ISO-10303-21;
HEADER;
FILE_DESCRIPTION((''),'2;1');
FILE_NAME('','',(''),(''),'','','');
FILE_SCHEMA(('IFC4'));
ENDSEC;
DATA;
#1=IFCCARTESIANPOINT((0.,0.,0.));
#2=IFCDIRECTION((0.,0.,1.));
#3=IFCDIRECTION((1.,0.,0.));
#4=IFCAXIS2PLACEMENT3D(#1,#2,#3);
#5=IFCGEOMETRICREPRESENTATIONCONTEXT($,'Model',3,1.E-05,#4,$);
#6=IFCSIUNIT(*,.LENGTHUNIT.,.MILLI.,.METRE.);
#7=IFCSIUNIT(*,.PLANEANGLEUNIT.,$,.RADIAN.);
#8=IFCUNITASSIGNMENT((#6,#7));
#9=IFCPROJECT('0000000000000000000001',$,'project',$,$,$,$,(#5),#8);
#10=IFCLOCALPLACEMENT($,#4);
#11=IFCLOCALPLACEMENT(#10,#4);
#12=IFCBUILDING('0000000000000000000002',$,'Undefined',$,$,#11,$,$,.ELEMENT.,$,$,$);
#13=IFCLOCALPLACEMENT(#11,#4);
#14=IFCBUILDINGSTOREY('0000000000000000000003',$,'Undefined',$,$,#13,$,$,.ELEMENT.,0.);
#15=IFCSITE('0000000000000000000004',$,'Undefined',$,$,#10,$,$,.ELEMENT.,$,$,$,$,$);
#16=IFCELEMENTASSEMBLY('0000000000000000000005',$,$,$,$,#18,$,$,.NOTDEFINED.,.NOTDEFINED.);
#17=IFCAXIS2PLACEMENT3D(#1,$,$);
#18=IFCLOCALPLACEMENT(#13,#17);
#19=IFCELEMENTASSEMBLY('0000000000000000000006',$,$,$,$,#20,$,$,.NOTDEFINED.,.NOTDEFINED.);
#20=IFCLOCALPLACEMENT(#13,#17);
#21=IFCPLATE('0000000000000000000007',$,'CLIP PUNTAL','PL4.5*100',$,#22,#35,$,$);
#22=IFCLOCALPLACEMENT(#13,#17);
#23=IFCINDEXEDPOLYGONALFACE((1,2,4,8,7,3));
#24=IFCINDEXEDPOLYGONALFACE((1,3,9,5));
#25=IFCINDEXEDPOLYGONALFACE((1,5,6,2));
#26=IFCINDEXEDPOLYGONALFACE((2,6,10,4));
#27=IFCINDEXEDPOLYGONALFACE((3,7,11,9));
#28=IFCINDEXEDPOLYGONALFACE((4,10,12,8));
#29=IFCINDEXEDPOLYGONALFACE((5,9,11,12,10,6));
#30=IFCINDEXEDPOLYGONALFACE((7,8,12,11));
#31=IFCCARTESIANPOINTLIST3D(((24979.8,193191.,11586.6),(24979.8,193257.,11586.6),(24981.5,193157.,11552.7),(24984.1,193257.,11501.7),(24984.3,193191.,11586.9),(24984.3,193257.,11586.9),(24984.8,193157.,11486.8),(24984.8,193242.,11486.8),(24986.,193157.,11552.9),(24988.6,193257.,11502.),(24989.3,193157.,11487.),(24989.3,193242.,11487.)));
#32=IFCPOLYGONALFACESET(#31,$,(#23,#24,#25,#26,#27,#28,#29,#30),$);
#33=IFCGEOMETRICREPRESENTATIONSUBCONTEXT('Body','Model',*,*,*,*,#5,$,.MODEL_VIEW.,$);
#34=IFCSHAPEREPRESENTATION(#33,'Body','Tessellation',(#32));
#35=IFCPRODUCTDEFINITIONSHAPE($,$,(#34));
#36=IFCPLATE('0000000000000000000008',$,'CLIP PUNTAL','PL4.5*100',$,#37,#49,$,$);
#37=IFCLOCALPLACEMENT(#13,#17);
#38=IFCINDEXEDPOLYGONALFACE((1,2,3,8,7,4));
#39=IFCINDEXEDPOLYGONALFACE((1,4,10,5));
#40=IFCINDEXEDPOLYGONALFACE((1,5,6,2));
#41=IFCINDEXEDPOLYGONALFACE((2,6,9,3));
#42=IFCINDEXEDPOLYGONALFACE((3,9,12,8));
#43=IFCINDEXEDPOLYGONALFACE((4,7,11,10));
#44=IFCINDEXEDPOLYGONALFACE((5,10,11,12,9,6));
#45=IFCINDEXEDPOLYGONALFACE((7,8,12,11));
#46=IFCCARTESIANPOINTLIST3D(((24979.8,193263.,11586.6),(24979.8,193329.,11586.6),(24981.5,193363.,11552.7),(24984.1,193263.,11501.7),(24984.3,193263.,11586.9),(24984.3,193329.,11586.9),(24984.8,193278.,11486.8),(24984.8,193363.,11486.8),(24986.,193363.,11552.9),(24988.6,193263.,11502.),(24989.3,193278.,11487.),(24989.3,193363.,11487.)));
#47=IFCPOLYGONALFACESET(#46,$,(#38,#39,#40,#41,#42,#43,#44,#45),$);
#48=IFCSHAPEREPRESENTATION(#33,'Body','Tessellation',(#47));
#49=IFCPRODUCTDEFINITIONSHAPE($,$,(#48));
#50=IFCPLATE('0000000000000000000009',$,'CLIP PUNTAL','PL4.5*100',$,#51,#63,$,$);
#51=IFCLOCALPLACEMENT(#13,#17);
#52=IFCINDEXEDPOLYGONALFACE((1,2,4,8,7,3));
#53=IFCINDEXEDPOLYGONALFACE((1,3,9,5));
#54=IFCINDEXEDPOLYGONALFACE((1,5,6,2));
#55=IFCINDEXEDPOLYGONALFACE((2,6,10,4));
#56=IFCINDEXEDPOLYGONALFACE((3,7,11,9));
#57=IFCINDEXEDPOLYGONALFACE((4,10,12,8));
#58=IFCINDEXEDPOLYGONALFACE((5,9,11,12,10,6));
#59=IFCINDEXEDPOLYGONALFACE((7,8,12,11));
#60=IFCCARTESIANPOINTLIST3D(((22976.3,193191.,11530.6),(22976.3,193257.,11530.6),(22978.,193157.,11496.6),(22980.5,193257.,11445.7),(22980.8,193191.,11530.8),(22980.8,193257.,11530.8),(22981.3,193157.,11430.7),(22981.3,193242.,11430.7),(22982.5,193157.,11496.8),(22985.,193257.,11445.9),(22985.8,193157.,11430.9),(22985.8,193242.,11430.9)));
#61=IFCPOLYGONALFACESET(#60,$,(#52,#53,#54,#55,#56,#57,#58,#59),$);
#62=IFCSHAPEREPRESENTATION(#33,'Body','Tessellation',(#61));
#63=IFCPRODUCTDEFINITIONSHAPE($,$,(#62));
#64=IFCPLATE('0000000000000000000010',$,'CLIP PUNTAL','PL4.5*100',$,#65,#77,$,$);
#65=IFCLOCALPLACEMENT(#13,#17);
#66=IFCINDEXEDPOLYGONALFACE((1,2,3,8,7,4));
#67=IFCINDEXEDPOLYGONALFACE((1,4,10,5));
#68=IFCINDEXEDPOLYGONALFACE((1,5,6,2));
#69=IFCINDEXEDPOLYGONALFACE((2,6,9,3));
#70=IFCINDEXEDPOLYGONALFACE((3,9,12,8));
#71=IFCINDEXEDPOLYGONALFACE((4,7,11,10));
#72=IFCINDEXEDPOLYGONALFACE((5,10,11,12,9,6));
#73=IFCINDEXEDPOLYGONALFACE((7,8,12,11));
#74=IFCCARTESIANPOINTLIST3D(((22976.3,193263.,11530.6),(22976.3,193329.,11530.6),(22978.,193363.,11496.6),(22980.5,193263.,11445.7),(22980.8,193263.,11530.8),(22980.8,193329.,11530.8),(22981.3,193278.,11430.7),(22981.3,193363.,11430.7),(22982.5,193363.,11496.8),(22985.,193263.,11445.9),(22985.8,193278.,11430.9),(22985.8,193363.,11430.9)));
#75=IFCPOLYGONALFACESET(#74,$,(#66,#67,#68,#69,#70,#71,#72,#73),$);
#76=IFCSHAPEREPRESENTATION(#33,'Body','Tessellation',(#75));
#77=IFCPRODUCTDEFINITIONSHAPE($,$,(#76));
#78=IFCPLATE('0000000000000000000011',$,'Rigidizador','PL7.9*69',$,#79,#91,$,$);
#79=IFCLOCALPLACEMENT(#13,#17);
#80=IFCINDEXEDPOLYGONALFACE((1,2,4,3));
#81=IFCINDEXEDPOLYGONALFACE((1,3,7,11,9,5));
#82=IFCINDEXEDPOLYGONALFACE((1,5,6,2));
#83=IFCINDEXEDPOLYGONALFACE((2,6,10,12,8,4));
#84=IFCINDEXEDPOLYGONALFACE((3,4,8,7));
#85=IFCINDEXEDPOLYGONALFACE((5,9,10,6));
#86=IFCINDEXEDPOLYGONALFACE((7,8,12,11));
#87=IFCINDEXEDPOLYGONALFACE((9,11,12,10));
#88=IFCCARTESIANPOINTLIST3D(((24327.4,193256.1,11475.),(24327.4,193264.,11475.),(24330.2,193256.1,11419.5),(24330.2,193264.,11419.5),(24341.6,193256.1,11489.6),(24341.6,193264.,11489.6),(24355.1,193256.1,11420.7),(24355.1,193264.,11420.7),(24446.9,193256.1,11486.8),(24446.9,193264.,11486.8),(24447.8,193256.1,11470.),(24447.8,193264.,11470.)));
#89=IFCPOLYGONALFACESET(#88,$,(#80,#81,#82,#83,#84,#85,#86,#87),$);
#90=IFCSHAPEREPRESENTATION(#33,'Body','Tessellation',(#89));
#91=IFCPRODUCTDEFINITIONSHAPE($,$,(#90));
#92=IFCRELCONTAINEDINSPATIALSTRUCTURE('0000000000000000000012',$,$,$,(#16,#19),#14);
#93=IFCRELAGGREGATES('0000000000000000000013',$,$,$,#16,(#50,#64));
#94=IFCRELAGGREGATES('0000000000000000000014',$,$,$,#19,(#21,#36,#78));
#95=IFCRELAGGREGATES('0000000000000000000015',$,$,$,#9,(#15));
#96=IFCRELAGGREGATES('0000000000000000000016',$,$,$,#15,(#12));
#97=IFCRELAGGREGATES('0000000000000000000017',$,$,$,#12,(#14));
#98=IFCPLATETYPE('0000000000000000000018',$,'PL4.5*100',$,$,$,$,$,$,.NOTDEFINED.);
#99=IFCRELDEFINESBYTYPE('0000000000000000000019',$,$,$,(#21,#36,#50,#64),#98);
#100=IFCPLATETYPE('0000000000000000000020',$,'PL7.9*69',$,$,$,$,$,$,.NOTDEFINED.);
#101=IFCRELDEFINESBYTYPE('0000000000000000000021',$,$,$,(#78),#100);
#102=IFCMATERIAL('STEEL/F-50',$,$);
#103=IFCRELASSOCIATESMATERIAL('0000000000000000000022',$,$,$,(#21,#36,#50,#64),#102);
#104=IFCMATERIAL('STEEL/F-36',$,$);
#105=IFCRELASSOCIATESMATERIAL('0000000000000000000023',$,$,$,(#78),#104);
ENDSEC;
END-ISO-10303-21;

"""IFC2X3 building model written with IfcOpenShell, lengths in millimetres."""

from ifc_helpers import new_model, si_unit, frame, origin_with_axes, place, context, subcontext, project, spatial, polyline, outline, extrude, material, type_object, element, aggregate, save


model = new_model("IFC2X3")

# Units and contexts
model_context = context("Model", 3, precision=1e-05, world=origin_with_axes())
body_context = subcontext(model_context, "Body", "Model", "MODEL_VIEW")
ifc_project = project(units=[si_unit("LENGTHUNIT", "METRE", prefix="MILLI"), si_unit("PLANEANGLEUNIT", "RADIAN")], contexts=[model_context])

# Site, building, storey
site_placement = place(None, origin_with_axes())
site = spatial("IfcSite", under=ifc_project, at=site_placement, Name="Undefined", CompositionType="ELEMENT")
building_placement = place(site_placement, origin_with_axes())
building = spatial("IfcBuilding", under=site, at=building_placement, Name="Undefined", CompositionType="ELEMENT")
storey_placement = place(building_placement, origin_with_axes())
storey = spatial("IfcBuildingStorey", under=building, at=storey_placement, Name="Undefined", CompositionType="ELEMENT", Elevation=0.0)

# Element assemblies
assembly_1_placement = place(storey_placement, origin_with_axes())
assembly_1 = element("IfcElementAssembly", 1, at=assembly_1_placement, inside=storey, AssemblyPlace="NOTDEFINED", PredefinedType="NOTDEFINED")
ifc_material_1 = material(Name="STEEL/F-50")
assembly_2_placement = place(storey_placement, origin_with_axes())
assembly_2 = element("IfcElementAssembly", 2, at=assembly_2_placement, inside=storey, AssemblyPlace="NOTDEFINED", PredefinedType="NOTDEFINED")
ifc_material_2 = material(Name="STEEL/F-36")

# Plates
plate_type_1 = type_object("IfcPlateType", Name="PL4.5*100", PredefinedType="NOTDEFINED")
plate_1_placement = place(assembly_2_placement, frame((24982.1, 193257.0, 11586.8), z_axis=(0.998754, 0.0, 0.049896), x_axis=(0.0, -1.0, 0.0)))
plate_1 = element("IfcPlate", 3, at=plate_1_placement, type_object=plate_type_1, material=ifc_material_1, Name="CLIP PUNTAL", Description="PL4.5*100", context=body_context, shape_type="SweptSolid", body=[
    extrude(outline(polyline([(0.0, 0.0), (66.0, 0.0), (100.0, 34.0), (100.0, 100.0), (15.0, 100.0), (0.0, 85.0), (0.0, 0.0)])), frame((0.0, 0.0, -2.2), z_axis=(0.0, 0.0, 1.0), x_axis=(1.0, 0.0, 0.0)), (0.0, 0.0, 1.0), 4.5),
])
plate_2_placement = place(assembly_2_placement, frame((24982.1, 193263.0, 11586.8), z_axis=(-0.998754, 0.0, -0.049896), x_axis=(0.0, 1.0, 0.0)))
plate_2 = element("IfcPlate", 4, at=plate_2_placement, type_object=plate_type_1, material=ifc_material_1, Name="CLIP PUNTAL", Description="PL4.5*100", context=body_context, shape_type="SweptSolid", body=[
    extrude(outline(polyline([(0.0, 0.0), (66.0, 0.0), (100.0, 34.0), (100.0, 100.0), (15.0, 100.0), (0.0, 85.0), (0.0, 0.0)])), frame((0.0, 0.0, -2.2), z_axis=(0.0, 0.0, 1.0), x_axis=(1.0, 0.0, 0.0)), (0.0, 0.0, 1.0), 4.5),
])
plate_3_placement = place(assembly_1_placement, frame((22978.5, 193257.0, 11530.7), z_axis=(0.998754, 0.0, 0.049896), x_axis=(0.0, -1.0, 0.0)))
plate_3 = element("IfcPlate", 5, at=plate_3_placement, type_object=plate_type_1, material=ifc_material_1, Name="CLIP PUNTAL", Description="PL4.5*100", context=body_context, shape_type="SweptSolid", body=[
    extrude(outline(polyline([(0.0, 0.0), (66.0, 0.0), (100.0, 34.0), (100.0, 100.0), (15.0, 100.0), (0.0, 85.0), (0.0, 0.0)])), frame((0.0, 0.0, -2.2), z_axis=(0.0, 0.0, 1.0), x_axis=(1.0, 0.0, 0.0)), (0.0, 0.0, 1.0), 4.5),
])
plate_4_placement = place(assembly_1_placement, frame((22978.5, 193263.0, 11530.7), z_axis=(-0.998754, 0.0, -0.049896), x_axis=(0.0, 1.0, 0.0)))
plate_4 = element("IfcPlate", 6, at=plate_4_placement, type_object=plate_type_1, material=ifc_material_1, Name="CLIP PUNTAL", Description="PL4.5*100", context=body_context, shape_type="SweptSolid", body=[
    extrude(outline(polyline([(0.0, 0.0), (66.0, 0.0), (100.0, 34.0), (100.0, 100.0), (15.0, 100.0), (0.0, 85.0), (0.0, 0.0)])), frame((0.0, 0.0, -2.2), z_axis=(0.0, 0.0, 1.0), x_axis=(1.0, 0.0, 0.0)), (0.0, 0.0, 1.0), 4.5),
])
aggregate(assembly_1, [plate_3, plate_4])
plate_type_2 = type_object("IfcPlateType", Name="PL7.9*69", PredefinedType="NOTDEFINED")
plate_5_placement = place(assembly_2_placement, frame((24330.2, 193260.0, 11419.5), z_axis=(0.0, 1.0, 0.0), x_axis=(-0.049943, 0.0, 0.998752)))
plate_5 = element("IfcPlate", 7, at=plate_5_placement, type_object=plate_type_2, material=ifc_material_2, Name="Rigidizador", Description="PL7.9*69", context=body_context, shape_type="SweptSolid", body=[
    extrude(outline(polyline([(0.0, 0.0), (55.6, 0.0), (69.4, 15.0), (61.3, 120.0), (44.5, 120.0), (-0.1, 25.0), (0.0, 0.0)])), frame((0.0, 0.0, -4.0), z_axis=(0.0, 0.0, 1.0), x_axis=(1.0, 0.0, 0.0)), (0.0, 0.0, 1.0), 7.9),
])

aggregate(assembly_2, [plate_1, plate_2, plate_5])

save(model, "model.ifc")
